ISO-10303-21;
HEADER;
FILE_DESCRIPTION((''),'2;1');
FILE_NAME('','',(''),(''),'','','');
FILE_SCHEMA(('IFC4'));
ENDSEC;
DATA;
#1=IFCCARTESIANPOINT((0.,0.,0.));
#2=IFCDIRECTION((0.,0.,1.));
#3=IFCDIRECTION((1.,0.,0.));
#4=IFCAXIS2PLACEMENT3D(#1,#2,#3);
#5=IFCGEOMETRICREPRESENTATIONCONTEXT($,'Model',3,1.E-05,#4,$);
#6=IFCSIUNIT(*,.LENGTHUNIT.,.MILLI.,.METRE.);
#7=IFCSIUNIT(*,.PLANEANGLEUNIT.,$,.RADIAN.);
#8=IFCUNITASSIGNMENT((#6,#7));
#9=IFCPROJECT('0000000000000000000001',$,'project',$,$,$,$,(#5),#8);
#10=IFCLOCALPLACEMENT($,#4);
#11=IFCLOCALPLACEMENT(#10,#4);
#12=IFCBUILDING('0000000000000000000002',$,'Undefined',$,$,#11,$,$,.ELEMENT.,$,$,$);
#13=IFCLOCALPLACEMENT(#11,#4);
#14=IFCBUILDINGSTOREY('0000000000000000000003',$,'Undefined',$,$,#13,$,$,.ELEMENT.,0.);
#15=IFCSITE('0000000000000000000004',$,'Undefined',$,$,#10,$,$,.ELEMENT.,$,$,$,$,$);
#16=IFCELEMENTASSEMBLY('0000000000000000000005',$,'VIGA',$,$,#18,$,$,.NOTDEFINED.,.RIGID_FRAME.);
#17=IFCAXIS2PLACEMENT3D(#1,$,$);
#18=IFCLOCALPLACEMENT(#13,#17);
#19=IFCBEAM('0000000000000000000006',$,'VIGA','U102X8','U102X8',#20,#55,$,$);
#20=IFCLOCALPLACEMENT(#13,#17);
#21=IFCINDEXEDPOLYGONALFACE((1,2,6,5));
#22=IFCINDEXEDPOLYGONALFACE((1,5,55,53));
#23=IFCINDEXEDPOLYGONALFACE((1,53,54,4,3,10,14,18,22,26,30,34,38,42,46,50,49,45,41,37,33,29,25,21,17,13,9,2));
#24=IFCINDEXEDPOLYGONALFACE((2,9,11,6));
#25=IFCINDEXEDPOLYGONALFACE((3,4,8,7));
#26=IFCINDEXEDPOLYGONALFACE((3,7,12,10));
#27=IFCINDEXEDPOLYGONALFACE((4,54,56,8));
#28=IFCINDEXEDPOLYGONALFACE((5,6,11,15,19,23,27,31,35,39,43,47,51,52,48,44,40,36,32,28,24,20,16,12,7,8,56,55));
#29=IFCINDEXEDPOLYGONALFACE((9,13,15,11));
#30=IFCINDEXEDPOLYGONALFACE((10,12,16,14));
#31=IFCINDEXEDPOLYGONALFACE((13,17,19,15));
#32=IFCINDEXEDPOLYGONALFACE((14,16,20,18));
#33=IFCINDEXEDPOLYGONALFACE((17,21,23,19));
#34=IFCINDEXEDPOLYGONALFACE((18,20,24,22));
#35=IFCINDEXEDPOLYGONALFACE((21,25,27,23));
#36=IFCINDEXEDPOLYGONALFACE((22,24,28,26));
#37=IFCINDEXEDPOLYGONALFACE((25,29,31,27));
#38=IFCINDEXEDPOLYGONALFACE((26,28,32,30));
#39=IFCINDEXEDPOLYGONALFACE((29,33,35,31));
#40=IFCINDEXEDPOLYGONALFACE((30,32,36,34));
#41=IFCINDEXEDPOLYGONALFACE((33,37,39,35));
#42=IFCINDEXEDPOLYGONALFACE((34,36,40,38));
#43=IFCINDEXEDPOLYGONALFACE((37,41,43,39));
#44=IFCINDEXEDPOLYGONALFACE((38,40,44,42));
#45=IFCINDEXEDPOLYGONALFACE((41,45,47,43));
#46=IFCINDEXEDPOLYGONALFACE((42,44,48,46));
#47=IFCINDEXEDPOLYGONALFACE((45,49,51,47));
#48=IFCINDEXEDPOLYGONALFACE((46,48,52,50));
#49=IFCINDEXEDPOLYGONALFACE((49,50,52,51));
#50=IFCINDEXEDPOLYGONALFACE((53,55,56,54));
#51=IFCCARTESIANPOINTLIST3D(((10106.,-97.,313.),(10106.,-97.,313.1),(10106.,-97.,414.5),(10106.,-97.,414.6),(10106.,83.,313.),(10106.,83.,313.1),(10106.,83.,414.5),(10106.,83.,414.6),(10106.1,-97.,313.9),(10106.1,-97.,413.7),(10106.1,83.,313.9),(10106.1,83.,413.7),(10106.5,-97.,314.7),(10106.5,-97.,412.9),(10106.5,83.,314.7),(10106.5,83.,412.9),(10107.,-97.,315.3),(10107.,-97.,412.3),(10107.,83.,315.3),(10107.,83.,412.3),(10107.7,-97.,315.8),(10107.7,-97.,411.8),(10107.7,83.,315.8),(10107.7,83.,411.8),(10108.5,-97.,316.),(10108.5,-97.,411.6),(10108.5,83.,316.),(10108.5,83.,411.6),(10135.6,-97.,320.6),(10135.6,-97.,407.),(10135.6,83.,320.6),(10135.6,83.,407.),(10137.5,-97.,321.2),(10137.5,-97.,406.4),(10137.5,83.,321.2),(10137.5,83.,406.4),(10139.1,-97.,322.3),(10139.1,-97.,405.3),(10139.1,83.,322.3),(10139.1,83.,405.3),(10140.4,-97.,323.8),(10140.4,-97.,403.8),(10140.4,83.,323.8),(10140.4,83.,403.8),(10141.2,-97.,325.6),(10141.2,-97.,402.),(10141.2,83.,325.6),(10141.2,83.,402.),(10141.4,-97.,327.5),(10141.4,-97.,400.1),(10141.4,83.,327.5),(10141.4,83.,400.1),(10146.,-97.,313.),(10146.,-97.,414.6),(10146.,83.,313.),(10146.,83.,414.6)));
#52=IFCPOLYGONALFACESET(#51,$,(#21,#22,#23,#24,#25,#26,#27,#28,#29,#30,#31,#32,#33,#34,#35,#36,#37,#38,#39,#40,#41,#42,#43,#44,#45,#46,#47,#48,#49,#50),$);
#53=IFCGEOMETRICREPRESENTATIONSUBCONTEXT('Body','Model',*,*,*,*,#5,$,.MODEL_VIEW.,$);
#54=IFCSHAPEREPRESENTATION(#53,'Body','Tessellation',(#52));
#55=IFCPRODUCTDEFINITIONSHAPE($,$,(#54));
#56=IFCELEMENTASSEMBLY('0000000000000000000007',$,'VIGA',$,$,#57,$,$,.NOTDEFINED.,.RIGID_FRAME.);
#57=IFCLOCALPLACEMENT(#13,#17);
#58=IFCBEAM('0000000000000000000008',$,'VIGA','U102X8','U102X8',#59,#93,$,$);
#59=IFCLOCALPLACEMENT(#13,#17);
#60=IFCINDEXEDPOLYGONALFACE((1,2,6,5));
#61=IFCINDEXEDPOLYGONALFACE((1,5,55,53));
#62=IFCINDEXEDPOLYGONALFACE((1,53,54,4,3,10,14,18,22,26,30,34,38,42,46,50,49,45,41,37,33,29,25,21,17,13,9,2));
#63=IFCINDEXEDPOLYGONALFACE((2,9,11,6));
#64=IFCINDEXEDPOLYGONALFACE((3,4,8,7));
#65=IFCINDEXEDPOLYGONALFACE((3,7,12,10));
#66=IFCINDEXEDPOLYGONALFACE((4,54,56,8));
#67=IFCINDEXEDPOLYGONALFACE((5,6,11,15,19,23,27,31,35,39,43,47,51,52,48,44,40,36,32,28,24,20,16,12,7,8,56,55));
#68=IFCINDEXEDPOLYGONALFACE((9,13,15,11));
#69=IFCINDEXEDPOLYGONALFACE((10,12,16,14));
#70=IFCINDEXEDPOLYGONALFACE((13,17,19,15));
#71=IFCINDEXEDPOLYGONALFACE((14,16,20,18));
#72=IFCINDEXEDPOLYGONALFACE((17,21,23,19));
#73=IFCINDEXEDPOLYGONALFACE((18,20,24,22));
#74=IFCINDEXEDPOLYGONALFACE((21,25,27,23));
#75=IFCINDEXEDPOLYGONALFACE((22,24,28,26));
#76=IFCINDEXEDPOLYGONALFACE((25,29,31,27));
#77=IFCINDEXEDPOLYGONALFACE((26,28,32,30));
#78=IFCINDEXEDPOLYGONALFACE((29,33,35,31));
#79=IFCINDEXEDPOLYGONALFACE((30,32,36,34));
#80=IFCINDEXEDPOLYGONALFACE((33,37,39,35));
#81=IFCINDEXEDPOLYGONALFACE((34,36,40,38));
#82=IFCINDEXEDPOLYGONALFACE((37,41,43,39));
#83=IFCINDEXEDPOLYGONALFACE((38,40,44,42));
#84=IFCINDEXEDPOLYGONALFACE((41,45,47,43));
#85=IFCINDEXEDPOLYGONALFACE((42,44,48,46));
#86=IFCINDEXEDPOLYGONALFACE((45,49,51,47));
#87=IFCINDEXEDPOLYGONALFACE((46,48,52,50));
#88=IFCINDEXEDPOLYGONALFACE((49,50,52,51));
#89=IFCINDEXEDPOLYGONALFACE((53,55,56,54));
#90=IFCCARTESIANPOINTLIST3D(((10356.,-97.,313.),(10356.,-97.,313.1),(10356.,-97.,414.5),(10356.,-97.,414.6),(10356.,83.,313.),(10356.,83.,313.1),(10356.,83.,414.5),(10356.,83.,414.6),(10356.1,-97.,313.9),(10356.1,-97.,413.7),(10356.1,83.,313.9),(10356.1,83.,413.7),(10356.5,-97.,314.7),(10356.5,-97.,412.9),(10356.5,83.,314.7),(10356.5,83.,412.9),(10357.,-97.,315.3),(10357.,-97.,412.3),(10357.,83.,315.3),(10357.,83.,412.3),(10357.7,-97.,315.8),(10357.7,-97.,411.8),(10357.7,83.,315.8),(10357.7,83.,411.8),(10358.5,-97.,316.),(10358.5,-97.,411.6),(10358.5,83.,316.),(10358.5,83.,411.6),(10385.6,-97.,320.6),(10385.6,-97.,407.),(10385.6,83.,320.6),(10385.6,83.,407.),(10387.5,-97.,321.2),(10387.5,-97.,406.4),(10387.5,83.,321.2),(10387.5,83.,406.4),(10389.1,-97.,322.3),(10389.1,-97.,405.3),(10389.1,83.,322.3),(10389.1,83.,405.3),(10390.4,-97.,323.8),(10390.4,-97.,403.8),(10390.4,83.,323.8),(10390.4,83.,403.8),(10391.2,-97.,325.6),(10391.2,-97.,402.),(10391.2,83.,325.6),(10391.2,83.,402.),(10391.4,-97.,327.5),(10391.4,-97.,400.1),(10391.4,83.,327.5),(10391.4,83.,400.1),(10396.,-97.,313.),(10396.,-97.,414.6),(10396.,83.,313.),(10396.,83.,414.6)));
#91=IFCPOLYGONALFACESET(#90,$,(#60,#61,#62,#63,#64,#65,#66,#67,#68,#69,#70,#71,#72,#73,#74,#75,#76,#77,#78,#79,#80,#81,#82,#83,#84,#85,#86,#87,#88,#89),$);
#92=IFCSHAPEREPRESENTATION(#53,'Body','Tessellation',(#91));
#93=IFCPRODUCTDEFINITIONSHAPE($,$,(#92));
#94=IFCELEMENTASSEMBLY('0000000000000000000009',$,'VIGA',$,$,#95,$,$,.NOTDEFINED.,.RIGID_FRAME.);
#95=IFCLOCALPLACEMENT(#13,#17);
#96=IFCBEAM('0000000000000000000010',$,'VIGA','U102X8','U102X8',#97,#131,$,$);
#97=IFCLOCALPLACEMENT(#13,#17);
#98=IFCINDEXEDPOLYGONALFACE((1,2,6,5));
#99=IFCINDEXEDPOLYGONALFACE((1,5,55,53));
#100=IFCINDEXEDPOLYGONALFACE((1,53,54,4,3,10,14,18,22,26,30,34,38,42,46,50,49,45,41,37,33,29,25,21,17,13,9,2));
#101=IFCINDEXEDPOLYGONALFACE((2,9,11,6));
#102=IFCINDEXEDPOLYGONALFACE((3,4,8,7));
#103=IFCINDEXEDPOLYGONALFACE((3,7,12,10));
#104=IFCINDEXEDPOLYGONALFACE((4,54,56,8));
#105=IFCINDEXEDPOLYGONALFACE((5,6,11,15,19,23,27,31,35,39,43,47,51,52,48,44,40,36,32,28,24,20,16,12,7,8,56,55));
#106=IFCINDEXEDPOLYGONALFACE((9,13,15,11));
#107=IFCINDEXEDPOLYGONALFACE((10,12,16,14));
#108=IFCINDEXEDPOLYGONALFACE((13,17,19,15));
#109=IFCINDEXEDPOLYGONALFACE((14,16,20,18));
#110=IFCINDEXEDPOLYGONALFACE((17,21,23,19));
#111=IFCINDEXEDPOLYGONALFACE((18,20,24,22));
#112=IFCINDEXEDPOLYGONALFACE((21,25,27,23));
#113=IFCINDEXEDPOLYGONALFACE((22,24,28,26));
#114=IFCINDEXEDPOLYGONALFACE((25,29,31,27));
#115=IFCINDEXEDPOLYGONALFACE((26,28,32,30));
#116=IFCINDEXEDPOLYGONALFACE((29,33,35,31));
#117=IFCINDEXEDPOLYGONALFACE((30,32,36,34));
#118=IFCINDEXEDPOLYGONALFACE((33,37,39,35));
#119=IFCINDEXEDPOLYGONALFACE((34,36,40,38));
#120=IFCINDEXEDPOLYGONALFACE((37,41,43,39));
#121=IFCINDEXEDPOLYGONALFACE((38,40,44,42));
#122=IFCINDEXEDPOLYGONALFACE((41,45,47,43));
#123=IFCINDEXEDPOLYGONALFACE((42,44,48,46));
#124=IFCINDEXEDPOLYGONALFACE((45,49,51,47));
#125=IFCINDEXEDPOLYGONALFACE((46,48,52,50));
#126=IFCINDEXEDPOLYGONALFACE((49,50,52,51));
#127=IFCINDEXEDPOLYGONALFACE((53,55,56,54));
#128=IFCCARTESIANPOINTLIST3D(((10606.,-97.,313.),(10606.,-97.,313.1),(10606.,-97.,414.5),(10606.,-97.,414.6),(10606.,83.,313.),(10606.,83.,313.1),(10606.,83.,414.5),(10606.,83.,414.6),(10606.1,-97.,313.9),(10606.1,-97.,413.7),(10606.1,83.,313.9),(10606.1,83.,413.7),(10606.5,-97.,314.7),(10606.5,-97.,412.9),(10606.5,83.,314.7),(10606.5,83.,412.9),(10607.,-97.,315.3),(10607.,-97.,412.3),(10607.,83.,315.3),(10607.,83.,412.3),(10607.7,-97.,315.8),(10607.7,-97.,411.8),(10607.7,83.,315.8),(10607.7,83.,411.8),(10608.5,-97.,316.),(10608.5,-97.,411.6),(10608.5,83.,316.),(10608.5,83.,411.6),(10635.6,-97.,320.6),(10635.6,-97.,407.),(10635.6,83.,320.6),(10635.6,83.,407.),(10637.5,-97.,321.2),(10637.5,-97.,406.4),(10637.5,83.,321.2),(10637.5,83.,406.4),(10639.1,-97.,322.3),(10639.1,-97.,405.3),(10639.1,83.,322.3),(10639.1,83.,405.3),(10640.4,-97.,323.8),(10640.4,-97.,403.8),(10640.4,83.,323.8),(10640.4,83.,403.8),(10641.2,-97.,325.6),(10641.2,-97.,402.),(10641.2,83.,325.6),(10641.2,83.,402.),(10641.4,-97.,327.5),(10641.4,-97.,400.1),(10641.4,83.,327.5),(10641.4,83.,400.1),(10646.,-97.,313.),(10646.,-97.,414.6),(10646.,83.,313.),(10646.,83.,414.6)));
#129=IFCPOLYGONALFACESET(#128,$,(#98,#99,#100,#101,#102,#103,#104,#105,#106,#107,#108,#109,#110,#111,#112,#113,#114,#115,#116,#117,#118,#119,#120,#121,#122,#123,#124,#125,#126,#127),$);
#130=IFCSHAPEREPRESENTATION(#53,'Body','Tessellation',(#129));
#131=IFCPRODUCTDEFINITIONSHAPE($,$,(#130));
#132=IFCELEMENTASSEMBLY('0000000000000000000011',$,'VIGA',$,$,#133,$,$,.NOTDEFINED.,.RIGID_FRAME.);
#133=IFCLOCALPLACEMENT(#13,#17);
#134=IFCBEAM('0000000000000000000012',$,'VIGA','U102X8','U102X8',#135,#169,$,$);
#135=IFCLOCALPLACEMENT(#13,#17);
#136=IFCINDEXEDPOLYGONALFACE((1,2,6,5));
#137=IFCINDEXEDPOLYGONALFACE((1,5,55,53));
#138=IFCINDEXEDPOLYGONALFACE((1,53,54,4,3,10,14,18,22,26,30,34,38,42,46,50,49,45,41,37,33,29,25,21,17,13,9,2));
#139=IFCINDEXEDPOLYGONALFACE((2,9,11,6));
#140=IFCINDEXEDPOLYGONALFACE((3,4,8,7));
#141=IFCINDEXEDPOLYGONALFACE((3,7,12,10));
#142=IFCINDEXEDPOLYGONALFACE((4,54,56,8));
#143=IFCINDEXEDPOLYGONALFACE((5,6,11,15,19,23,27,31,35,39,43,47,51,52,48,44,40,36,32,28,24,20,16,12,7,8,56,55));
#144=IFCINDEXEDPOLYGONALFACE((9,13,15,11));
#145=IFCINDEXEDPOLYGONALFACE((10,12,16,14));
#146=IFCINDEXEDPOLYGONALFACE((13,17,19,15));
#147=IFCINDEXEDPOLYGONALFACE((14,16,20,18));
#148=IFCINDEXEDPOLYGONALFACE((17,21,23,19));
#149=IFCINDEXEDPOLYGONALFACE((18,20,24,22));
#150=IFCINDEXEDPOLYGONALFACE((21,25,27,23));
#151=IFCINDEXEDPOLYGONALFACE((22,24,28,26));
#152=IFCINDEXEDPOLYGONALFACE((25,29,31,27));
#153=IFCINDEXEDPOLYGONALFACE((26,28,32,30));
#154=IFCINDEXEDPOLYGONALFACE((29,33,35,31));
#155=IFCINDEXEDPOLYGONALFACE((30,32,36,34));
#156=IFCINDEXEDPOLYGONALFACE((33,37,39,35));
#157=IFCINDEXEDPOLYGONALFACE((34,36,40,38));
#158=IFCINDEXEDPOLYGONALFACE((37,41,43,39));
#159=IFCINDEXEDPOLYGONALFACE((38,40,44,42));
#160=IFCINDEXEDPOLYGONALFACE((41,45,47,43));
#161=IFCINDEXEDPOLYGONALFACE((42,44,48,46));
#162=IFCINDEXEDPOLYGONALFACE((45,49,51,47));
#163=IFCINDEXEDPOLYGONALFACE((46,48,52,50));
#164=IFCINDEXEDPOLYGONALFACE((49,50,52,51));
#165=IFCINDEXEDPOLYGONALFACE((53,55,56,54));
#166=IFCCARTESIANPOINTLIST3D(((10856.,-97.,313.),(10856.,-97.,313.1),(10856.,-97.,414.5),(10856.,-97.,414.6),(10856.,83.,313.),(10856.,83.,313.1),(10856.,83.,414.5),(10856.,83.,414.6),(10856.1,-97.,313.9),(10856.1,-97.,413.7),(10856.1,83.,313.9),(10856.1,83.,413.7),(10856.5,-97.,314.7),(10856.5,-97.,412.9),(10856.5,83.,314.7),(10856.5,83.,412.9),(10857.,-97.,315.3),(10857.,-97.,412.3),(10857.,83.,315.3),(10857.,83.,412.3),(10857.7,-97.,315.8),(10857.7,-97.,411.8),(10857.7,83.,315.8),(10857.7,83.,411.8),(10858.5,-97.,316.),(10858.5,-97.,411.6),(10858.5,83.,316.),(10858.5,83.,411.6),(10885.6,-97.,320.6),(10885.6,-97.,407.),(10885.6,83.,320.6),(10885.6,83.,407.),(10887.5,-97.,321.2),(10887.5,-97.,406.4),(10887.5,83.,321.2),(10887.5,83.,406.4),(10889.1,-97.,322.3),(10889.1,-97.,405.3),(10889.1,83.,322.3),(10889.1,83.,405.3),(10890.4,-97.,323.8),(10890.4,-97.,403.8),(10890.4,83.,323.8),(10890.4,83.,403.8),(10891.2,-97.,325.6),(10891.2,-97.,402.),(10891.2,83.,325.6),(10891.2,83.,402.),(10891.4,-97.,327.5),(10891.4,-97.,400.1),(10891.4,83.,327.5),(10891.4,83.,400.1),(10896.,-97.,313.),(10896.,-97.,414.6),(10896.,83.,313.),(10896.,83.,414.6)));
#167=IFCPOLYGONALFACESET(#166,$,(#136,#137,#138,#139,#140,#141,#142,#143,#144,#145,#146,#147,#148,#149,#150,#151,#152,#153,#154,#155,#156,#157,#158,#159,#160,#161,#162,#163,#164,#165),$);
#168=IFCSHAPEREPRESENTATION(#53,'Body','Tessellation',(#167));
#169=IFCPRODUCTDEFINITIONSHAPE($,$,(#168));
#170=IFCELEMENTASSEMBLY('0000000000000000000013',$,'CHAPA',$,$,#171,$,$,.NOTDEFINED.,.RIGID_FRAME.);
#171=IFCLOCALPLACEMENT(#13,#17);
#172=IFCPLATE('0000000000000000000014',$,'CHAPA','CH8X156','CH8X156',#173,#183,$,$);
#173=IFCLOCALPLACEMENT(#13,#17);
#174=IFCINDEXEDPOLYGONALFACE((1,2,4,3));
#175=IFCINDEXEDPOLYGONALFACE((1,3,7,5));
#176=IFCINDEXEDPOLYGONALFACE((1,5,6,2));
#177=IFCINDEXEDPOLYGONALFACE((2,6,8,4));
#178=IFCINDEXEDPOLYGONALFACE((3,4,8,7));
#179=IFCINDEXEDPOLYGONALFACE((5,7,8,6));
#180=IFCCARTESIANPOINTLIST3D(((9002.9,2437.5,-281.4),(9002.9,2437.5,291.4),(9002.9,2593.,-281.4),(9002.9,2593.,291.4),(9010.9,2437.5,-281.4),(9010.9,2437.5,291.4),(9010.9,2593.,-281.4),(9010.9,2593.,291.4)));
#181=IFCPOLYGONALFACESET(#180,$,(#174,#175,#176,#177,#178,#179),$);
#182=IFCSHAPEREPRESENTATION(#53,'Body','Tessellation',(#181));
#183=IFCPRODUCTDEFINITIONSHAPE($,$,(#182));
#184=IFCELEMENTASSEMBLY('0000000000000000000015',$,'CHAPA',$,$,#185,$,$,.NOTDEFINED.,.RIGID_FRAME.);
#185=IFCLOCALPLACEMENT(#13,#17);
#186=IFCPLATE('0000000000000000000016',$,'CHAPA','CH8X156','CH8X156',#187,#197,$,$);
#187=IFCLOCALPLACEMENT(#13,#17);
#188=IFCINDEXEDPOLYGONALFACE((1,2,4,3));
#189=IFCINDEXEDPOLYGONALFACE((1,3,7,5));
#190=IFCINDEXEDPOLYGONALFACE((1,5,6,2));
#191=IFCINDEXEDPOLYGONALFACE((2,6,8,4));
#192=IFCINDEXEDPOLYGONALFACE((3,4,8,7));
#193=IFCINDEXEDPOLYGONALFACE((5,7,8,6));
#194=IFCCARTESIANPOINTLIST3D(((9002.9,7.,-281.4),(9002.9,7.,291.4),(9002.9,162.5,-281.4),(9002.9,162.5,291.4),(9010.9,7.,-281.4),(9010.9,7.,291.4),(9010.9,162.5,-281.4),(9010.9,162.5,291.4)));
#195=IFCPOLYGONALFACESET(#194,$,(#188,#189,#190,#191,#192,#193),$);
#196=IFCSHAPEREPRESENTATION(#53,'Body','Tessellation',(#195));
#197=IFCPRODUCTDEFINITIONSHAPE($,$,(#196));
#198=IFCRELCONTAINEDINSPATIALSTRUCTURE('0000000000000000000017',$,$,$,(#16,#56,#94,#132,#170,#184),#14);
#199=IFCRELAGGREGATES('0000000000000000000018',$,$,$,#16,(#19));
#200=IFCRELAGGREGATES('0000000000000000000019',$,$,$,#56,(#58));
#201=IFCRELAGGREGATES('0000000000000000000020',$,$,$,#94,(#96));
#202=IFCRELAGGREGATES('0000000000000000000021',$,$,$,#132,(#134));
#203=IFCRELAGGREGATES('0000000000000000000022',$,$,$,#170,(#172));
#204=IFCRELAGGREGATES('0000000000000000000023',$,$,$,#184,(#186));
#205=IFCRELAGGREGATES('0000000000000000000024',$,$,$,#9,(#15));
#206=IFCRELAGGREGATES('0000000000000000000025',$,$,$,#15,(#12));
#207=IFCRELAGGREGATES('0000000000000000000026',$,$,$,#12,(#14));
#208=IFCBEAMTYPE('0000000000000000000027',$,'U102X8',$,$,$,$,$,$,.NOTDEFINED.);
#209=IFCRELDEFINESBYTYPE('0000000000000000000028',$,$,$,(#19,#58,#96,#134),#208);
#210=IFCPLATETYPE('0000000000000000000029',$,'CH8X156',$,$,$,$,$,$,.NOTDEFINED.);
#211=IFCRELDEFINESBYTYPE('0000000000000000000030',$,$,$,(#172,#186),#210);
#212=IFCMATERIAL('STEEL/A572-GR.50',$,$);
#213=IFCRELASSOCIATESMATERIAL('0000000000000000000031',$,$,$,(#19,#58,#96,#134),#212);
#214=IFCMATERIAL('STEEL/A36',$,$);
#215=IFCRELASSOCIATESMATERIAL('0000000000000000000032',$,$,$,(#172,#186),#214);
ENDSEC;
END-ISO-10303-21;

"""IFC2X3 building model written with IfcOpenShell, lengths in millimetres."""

from ifc_helpers import new_model, si_unit, frame, origin_with_axes, origin_2d_with_axis, place, context, subcontext, project, spatial, polyline, u_section, outline, extrude, material, type_object, element, aggregate, save


model = new_model("IFC2X3")

# Units and contexts
model_context = context("Model", 3, precision=1e-05, world=origin_with_axes())
body_context = subcontext(model_context, "Body", "Model", "MODEL_VIEW")
ifc_project = project(units=[si_unit("LENGTHUNIT", "METRE", prefix="MILLI"), si_unit("PLANEANGLEUNIT", "RADIAN")], contexts=[model_context])

# Site, building, storey
site_placement = place(None, origin_with_axes())
site = spatial("IfcSite", under=ifc_project, at=site_placement, Name="Undefined", CompositionType="ELEMENT")
building_placement = place(site_placement, origin_with_axes())
building = spatial("IfcBuilding", under=site, at=building_placement, Name="Undefined", CompositionType="ELEMENT")
storey_placement = place(building_placement, origin_with_axes())
storey = spatial("IfcBuildingStorey", under=building, at=storey_placement, Name="Undefined", CompositionType="ELEMENT", Elevation=0.0)

# Element assemblies, beams
ifc_material_1 = material(Name="STEEL/A572-GR.50")
beam_type = type_object("IfcBeamType", Name="U102X8", PredefinedType="NOTDEFINED")
assembly_1_placement = place(storey_placement, origin_with_axes())
assembly_1 = element("IfcElementAssembly", 1, at=assembly_1_placement, inside=storey, Name="VIGA", AssemblyPlace="NOTDEFINED", PredefinedType="RIGID_FRAME")
beam_1_placement = place(assembly_1_placement, frame((10126.0, 83.0, 363.8), z_axis=(0.0, 0.0, 1.0), x_axis=(0.0, -1.0, 0.0)))
beam_1 = element("IfcBeam", 2, at=beam_1_placement, type_object=beam_type, material=ifc_material_1, Name="VIGA", Description="U102X8", ObjectType="U102X8", context=body_context, shape_type="SweptSolid", body=[
    extrude(u_section(Depth=101.6, FlangeWidth=40.0, WebThickness=4.6, FlangeThickness=6.0, FilletRadius=7.0, EdgeRadius=3.0, FlangeSlope=0.16839, at=origin_2d_with_axis()), frame((180.0, 0.0, 0.0), z_axis=(-1.0, 0.0, 0.0), x_axis=(0.0, -1.0, 0.0)), (0.0, 0.0, 1.0), 180.0),
])
aggregate(assembly_1, [beam_1])
assembly_2_placement = place(storey_placement, origin_with_axes())
assembly_2 = element("IfcElementAssembly", 3, at=assembly_2_placement, inside=storey, Name="VIGA", AssemblyPlace="NOTDEFINED", PredefinedType="RIGID_FRAME")
beam_2_placement = place(assembly_2_placement, frame((10376.0, 83.0, 363.8), z_axis=(0.0, 0.0, 1.0), x_axis=(0.0, -1.0, 0.0)))
beam_2 = element("IfcBeam", 4, at=beam_2_placement, type_object=beam_type, material=ifc_material_1, Name="VIGA", Description="U102X8", ObjectType="U102X8", context=body_context, shape_type="SweptSolid", body=[
    extrude(u_section(Depth=101.6, FlangeWidth=40.0, WebThickness=4.6, FlangeThickness=6.0, FilletRadius=7.0, EdgeRadius=3.0, FlangeSlope=0.16839, at=origin_2d_with_axis()), frame((180.0, 0.0, 0.0), z_axis=(-1.0, 0.0, 0.0), x_axis=(0.0, -1.0, 0.0)), (0.0, 0.0, 1.0), 180.0),
])
aggregate(assembly_2, [beam_2])
assembly_3_placement = place(storey_placement, origin_with_axes())
assembly_3 = element("IfcElementAssembly", 5, at=assembly_3_placement, inside=storey, Name="VIGA", AssemblyPlace="NOTDEFINED", PredefinedType="RIGID_FRAME")
beam_3_placement = place(assembly_3_placement, frame((10626.0, 83.0, 363.8), z_axis=(0.0, 0.0, 1.0), x_axis=(0.0, -1.0, 0.0)))
beam_3 = element("IfcBeam", 6, at=beam_3_placement, type_object=beam_type, material=ifc_material_1, Name="VIGA", Description="U102X8", ObjectType="U102X8", context=body_context, shape_type="SweptSolid", body=[
    extrude(u_section(Depth=101.6, FlangeWidth=40.0, WebThickness=4.6, FlangeThickness=6.0, FilletRadius=7.0, EdgeRadius=3.0, FlangeSlope=0.16839, at=origin_2d_with_axis()), frame((180.0, 0.0, 0.0), z_axis=(-1.0, 0.0, 0.0), x_axis=(0.0, -1.0, 0.0)), (0.0, 0.0, 1.0), 180.0),
])
aggregate(assembly_3, [beam_3])
assembly_4_placement = place(storey_placement, origin_with_axes())
assembly_4 = element("IfcElementAssembly", 7, at=assembly_4_placement, inside=storey, Name="VIGA", AssemblyPlace="NOTDEFINED", PredefinedType="RIGID_FRAME")
beam_4_placement = place(assembly_4_placement, frame((10876.0, 83.0, 363.8), z_axis=(0.0, 0.0, 1.0), x_axis=(0.0, -1.0, 0.0)))
beam_4 = element("IfcBeam", 8, at=beam_4_placement, type_object=beam_type, material=ifc_material_1, Name="VIGA", Description="U102X8", ObjectType="U102X8", context=body_context, shape_type="SweptSolid", body=[
    extrude(u_section(Depth=101.6, FlangeWidth=40.0, WebThickness=4.6, FlangeThickness=6.0, FilletRadius=7.0, EdgeRadius=3.0, FlangeSlope=0.16839, at=origin_2d_with_axis()), frame((180.0, 0.0, 0.0), z_axis=(-1.0, 0.0, 0.0), x_axis=(0.0, -1.0, 0.0)), (0.0, 0.0, 1.0), 180.0),
])
aggregate(assembly_4, [beam_4])

# Element assemblies, plates
assembly_5_placement = place(storey_placement, origin_with_axes())
assembly_5 = element("IfcElementAssembly", 9, at=assembly_5_placement, inside=storey, Name="CHAPA", AssemblyPlace="NOTDEFINED", PredefinedType="RIGID_FRAME")
ifc_material_2 = material(Name="STEEL/A36")
plate_type = type_object("IfcPlateType", Name="CH8X156", PredefinedType="NOTDEFINED")
plate_1_placement = place(assembly_5_placement, frame((9006.9, 2593.0, 291.4), z_axis=(1.0, 0.0, 0.0), x_axis=(0.0, -1.0, 0.0)))
plate_1 = element("IfcPlate", 10, at=plate_1_placement, type_object=plate_type, material=ifc_material_2, Name="CHAPA", Description="CH8X156", ObjectType="CH8X156", context=body_context, shape_type="SweptSolid", body=[
    extrude(outline(polyline([(0.0, 0.0), (155.5, 0.0), (155.5, 572.8), (0.0, 572.8), (0.0, 0.0)])), frame((0.0, 0.0, -4.0), z_axis=(0.0, 0.0, 1.0), x_axis=(1.0, 0.0, 0.0)), (0.0, 0.0, 1.0), 8.0),
])
aggregate(assembly_5, [plate_1])
assembly_6_placement = place(storey_placement, origin_with_axes())
assembly_6 = element("IfcElementAssembly", 11, at=assembly_6_placement, inside=storey, Name="CHAPA", AssemblyPlace="NOTDEFINED", PredefinedType="RIGID_FRAME")
plate_2_placement = place(assembly_6_placement, frame((9006.9, 162.5, 291.4), z_axis=(1.0, 0.0, 0.0), x_axis=(0.0, -1.0, 0.0)))
plate_2 = element("IfcPlate", 12, at=plate_2_placement, type_object=plate_type, material=ifc_material_2, Name="CHAPA", Description="CH8X156", ObjectType="CH8X156", context=body_context, shape_type="SweptSolid", body=[
    extrude(outline(polyline([(0.0, 0.0), (155.5, 0.0), (155.5, 572.8), (0.0, 572.8), (0.0, 0.0)])), frame((0.0, 0.0, -4.0), z_axis=(0.0, 0.0, 1.0), x_axis=(1.0, 0.0, 0.0)), (0.0, 0.0, 1.0), 8.0),
])
aggregate(assembly_6, [plate_2])

save(model, "model.ifc")
